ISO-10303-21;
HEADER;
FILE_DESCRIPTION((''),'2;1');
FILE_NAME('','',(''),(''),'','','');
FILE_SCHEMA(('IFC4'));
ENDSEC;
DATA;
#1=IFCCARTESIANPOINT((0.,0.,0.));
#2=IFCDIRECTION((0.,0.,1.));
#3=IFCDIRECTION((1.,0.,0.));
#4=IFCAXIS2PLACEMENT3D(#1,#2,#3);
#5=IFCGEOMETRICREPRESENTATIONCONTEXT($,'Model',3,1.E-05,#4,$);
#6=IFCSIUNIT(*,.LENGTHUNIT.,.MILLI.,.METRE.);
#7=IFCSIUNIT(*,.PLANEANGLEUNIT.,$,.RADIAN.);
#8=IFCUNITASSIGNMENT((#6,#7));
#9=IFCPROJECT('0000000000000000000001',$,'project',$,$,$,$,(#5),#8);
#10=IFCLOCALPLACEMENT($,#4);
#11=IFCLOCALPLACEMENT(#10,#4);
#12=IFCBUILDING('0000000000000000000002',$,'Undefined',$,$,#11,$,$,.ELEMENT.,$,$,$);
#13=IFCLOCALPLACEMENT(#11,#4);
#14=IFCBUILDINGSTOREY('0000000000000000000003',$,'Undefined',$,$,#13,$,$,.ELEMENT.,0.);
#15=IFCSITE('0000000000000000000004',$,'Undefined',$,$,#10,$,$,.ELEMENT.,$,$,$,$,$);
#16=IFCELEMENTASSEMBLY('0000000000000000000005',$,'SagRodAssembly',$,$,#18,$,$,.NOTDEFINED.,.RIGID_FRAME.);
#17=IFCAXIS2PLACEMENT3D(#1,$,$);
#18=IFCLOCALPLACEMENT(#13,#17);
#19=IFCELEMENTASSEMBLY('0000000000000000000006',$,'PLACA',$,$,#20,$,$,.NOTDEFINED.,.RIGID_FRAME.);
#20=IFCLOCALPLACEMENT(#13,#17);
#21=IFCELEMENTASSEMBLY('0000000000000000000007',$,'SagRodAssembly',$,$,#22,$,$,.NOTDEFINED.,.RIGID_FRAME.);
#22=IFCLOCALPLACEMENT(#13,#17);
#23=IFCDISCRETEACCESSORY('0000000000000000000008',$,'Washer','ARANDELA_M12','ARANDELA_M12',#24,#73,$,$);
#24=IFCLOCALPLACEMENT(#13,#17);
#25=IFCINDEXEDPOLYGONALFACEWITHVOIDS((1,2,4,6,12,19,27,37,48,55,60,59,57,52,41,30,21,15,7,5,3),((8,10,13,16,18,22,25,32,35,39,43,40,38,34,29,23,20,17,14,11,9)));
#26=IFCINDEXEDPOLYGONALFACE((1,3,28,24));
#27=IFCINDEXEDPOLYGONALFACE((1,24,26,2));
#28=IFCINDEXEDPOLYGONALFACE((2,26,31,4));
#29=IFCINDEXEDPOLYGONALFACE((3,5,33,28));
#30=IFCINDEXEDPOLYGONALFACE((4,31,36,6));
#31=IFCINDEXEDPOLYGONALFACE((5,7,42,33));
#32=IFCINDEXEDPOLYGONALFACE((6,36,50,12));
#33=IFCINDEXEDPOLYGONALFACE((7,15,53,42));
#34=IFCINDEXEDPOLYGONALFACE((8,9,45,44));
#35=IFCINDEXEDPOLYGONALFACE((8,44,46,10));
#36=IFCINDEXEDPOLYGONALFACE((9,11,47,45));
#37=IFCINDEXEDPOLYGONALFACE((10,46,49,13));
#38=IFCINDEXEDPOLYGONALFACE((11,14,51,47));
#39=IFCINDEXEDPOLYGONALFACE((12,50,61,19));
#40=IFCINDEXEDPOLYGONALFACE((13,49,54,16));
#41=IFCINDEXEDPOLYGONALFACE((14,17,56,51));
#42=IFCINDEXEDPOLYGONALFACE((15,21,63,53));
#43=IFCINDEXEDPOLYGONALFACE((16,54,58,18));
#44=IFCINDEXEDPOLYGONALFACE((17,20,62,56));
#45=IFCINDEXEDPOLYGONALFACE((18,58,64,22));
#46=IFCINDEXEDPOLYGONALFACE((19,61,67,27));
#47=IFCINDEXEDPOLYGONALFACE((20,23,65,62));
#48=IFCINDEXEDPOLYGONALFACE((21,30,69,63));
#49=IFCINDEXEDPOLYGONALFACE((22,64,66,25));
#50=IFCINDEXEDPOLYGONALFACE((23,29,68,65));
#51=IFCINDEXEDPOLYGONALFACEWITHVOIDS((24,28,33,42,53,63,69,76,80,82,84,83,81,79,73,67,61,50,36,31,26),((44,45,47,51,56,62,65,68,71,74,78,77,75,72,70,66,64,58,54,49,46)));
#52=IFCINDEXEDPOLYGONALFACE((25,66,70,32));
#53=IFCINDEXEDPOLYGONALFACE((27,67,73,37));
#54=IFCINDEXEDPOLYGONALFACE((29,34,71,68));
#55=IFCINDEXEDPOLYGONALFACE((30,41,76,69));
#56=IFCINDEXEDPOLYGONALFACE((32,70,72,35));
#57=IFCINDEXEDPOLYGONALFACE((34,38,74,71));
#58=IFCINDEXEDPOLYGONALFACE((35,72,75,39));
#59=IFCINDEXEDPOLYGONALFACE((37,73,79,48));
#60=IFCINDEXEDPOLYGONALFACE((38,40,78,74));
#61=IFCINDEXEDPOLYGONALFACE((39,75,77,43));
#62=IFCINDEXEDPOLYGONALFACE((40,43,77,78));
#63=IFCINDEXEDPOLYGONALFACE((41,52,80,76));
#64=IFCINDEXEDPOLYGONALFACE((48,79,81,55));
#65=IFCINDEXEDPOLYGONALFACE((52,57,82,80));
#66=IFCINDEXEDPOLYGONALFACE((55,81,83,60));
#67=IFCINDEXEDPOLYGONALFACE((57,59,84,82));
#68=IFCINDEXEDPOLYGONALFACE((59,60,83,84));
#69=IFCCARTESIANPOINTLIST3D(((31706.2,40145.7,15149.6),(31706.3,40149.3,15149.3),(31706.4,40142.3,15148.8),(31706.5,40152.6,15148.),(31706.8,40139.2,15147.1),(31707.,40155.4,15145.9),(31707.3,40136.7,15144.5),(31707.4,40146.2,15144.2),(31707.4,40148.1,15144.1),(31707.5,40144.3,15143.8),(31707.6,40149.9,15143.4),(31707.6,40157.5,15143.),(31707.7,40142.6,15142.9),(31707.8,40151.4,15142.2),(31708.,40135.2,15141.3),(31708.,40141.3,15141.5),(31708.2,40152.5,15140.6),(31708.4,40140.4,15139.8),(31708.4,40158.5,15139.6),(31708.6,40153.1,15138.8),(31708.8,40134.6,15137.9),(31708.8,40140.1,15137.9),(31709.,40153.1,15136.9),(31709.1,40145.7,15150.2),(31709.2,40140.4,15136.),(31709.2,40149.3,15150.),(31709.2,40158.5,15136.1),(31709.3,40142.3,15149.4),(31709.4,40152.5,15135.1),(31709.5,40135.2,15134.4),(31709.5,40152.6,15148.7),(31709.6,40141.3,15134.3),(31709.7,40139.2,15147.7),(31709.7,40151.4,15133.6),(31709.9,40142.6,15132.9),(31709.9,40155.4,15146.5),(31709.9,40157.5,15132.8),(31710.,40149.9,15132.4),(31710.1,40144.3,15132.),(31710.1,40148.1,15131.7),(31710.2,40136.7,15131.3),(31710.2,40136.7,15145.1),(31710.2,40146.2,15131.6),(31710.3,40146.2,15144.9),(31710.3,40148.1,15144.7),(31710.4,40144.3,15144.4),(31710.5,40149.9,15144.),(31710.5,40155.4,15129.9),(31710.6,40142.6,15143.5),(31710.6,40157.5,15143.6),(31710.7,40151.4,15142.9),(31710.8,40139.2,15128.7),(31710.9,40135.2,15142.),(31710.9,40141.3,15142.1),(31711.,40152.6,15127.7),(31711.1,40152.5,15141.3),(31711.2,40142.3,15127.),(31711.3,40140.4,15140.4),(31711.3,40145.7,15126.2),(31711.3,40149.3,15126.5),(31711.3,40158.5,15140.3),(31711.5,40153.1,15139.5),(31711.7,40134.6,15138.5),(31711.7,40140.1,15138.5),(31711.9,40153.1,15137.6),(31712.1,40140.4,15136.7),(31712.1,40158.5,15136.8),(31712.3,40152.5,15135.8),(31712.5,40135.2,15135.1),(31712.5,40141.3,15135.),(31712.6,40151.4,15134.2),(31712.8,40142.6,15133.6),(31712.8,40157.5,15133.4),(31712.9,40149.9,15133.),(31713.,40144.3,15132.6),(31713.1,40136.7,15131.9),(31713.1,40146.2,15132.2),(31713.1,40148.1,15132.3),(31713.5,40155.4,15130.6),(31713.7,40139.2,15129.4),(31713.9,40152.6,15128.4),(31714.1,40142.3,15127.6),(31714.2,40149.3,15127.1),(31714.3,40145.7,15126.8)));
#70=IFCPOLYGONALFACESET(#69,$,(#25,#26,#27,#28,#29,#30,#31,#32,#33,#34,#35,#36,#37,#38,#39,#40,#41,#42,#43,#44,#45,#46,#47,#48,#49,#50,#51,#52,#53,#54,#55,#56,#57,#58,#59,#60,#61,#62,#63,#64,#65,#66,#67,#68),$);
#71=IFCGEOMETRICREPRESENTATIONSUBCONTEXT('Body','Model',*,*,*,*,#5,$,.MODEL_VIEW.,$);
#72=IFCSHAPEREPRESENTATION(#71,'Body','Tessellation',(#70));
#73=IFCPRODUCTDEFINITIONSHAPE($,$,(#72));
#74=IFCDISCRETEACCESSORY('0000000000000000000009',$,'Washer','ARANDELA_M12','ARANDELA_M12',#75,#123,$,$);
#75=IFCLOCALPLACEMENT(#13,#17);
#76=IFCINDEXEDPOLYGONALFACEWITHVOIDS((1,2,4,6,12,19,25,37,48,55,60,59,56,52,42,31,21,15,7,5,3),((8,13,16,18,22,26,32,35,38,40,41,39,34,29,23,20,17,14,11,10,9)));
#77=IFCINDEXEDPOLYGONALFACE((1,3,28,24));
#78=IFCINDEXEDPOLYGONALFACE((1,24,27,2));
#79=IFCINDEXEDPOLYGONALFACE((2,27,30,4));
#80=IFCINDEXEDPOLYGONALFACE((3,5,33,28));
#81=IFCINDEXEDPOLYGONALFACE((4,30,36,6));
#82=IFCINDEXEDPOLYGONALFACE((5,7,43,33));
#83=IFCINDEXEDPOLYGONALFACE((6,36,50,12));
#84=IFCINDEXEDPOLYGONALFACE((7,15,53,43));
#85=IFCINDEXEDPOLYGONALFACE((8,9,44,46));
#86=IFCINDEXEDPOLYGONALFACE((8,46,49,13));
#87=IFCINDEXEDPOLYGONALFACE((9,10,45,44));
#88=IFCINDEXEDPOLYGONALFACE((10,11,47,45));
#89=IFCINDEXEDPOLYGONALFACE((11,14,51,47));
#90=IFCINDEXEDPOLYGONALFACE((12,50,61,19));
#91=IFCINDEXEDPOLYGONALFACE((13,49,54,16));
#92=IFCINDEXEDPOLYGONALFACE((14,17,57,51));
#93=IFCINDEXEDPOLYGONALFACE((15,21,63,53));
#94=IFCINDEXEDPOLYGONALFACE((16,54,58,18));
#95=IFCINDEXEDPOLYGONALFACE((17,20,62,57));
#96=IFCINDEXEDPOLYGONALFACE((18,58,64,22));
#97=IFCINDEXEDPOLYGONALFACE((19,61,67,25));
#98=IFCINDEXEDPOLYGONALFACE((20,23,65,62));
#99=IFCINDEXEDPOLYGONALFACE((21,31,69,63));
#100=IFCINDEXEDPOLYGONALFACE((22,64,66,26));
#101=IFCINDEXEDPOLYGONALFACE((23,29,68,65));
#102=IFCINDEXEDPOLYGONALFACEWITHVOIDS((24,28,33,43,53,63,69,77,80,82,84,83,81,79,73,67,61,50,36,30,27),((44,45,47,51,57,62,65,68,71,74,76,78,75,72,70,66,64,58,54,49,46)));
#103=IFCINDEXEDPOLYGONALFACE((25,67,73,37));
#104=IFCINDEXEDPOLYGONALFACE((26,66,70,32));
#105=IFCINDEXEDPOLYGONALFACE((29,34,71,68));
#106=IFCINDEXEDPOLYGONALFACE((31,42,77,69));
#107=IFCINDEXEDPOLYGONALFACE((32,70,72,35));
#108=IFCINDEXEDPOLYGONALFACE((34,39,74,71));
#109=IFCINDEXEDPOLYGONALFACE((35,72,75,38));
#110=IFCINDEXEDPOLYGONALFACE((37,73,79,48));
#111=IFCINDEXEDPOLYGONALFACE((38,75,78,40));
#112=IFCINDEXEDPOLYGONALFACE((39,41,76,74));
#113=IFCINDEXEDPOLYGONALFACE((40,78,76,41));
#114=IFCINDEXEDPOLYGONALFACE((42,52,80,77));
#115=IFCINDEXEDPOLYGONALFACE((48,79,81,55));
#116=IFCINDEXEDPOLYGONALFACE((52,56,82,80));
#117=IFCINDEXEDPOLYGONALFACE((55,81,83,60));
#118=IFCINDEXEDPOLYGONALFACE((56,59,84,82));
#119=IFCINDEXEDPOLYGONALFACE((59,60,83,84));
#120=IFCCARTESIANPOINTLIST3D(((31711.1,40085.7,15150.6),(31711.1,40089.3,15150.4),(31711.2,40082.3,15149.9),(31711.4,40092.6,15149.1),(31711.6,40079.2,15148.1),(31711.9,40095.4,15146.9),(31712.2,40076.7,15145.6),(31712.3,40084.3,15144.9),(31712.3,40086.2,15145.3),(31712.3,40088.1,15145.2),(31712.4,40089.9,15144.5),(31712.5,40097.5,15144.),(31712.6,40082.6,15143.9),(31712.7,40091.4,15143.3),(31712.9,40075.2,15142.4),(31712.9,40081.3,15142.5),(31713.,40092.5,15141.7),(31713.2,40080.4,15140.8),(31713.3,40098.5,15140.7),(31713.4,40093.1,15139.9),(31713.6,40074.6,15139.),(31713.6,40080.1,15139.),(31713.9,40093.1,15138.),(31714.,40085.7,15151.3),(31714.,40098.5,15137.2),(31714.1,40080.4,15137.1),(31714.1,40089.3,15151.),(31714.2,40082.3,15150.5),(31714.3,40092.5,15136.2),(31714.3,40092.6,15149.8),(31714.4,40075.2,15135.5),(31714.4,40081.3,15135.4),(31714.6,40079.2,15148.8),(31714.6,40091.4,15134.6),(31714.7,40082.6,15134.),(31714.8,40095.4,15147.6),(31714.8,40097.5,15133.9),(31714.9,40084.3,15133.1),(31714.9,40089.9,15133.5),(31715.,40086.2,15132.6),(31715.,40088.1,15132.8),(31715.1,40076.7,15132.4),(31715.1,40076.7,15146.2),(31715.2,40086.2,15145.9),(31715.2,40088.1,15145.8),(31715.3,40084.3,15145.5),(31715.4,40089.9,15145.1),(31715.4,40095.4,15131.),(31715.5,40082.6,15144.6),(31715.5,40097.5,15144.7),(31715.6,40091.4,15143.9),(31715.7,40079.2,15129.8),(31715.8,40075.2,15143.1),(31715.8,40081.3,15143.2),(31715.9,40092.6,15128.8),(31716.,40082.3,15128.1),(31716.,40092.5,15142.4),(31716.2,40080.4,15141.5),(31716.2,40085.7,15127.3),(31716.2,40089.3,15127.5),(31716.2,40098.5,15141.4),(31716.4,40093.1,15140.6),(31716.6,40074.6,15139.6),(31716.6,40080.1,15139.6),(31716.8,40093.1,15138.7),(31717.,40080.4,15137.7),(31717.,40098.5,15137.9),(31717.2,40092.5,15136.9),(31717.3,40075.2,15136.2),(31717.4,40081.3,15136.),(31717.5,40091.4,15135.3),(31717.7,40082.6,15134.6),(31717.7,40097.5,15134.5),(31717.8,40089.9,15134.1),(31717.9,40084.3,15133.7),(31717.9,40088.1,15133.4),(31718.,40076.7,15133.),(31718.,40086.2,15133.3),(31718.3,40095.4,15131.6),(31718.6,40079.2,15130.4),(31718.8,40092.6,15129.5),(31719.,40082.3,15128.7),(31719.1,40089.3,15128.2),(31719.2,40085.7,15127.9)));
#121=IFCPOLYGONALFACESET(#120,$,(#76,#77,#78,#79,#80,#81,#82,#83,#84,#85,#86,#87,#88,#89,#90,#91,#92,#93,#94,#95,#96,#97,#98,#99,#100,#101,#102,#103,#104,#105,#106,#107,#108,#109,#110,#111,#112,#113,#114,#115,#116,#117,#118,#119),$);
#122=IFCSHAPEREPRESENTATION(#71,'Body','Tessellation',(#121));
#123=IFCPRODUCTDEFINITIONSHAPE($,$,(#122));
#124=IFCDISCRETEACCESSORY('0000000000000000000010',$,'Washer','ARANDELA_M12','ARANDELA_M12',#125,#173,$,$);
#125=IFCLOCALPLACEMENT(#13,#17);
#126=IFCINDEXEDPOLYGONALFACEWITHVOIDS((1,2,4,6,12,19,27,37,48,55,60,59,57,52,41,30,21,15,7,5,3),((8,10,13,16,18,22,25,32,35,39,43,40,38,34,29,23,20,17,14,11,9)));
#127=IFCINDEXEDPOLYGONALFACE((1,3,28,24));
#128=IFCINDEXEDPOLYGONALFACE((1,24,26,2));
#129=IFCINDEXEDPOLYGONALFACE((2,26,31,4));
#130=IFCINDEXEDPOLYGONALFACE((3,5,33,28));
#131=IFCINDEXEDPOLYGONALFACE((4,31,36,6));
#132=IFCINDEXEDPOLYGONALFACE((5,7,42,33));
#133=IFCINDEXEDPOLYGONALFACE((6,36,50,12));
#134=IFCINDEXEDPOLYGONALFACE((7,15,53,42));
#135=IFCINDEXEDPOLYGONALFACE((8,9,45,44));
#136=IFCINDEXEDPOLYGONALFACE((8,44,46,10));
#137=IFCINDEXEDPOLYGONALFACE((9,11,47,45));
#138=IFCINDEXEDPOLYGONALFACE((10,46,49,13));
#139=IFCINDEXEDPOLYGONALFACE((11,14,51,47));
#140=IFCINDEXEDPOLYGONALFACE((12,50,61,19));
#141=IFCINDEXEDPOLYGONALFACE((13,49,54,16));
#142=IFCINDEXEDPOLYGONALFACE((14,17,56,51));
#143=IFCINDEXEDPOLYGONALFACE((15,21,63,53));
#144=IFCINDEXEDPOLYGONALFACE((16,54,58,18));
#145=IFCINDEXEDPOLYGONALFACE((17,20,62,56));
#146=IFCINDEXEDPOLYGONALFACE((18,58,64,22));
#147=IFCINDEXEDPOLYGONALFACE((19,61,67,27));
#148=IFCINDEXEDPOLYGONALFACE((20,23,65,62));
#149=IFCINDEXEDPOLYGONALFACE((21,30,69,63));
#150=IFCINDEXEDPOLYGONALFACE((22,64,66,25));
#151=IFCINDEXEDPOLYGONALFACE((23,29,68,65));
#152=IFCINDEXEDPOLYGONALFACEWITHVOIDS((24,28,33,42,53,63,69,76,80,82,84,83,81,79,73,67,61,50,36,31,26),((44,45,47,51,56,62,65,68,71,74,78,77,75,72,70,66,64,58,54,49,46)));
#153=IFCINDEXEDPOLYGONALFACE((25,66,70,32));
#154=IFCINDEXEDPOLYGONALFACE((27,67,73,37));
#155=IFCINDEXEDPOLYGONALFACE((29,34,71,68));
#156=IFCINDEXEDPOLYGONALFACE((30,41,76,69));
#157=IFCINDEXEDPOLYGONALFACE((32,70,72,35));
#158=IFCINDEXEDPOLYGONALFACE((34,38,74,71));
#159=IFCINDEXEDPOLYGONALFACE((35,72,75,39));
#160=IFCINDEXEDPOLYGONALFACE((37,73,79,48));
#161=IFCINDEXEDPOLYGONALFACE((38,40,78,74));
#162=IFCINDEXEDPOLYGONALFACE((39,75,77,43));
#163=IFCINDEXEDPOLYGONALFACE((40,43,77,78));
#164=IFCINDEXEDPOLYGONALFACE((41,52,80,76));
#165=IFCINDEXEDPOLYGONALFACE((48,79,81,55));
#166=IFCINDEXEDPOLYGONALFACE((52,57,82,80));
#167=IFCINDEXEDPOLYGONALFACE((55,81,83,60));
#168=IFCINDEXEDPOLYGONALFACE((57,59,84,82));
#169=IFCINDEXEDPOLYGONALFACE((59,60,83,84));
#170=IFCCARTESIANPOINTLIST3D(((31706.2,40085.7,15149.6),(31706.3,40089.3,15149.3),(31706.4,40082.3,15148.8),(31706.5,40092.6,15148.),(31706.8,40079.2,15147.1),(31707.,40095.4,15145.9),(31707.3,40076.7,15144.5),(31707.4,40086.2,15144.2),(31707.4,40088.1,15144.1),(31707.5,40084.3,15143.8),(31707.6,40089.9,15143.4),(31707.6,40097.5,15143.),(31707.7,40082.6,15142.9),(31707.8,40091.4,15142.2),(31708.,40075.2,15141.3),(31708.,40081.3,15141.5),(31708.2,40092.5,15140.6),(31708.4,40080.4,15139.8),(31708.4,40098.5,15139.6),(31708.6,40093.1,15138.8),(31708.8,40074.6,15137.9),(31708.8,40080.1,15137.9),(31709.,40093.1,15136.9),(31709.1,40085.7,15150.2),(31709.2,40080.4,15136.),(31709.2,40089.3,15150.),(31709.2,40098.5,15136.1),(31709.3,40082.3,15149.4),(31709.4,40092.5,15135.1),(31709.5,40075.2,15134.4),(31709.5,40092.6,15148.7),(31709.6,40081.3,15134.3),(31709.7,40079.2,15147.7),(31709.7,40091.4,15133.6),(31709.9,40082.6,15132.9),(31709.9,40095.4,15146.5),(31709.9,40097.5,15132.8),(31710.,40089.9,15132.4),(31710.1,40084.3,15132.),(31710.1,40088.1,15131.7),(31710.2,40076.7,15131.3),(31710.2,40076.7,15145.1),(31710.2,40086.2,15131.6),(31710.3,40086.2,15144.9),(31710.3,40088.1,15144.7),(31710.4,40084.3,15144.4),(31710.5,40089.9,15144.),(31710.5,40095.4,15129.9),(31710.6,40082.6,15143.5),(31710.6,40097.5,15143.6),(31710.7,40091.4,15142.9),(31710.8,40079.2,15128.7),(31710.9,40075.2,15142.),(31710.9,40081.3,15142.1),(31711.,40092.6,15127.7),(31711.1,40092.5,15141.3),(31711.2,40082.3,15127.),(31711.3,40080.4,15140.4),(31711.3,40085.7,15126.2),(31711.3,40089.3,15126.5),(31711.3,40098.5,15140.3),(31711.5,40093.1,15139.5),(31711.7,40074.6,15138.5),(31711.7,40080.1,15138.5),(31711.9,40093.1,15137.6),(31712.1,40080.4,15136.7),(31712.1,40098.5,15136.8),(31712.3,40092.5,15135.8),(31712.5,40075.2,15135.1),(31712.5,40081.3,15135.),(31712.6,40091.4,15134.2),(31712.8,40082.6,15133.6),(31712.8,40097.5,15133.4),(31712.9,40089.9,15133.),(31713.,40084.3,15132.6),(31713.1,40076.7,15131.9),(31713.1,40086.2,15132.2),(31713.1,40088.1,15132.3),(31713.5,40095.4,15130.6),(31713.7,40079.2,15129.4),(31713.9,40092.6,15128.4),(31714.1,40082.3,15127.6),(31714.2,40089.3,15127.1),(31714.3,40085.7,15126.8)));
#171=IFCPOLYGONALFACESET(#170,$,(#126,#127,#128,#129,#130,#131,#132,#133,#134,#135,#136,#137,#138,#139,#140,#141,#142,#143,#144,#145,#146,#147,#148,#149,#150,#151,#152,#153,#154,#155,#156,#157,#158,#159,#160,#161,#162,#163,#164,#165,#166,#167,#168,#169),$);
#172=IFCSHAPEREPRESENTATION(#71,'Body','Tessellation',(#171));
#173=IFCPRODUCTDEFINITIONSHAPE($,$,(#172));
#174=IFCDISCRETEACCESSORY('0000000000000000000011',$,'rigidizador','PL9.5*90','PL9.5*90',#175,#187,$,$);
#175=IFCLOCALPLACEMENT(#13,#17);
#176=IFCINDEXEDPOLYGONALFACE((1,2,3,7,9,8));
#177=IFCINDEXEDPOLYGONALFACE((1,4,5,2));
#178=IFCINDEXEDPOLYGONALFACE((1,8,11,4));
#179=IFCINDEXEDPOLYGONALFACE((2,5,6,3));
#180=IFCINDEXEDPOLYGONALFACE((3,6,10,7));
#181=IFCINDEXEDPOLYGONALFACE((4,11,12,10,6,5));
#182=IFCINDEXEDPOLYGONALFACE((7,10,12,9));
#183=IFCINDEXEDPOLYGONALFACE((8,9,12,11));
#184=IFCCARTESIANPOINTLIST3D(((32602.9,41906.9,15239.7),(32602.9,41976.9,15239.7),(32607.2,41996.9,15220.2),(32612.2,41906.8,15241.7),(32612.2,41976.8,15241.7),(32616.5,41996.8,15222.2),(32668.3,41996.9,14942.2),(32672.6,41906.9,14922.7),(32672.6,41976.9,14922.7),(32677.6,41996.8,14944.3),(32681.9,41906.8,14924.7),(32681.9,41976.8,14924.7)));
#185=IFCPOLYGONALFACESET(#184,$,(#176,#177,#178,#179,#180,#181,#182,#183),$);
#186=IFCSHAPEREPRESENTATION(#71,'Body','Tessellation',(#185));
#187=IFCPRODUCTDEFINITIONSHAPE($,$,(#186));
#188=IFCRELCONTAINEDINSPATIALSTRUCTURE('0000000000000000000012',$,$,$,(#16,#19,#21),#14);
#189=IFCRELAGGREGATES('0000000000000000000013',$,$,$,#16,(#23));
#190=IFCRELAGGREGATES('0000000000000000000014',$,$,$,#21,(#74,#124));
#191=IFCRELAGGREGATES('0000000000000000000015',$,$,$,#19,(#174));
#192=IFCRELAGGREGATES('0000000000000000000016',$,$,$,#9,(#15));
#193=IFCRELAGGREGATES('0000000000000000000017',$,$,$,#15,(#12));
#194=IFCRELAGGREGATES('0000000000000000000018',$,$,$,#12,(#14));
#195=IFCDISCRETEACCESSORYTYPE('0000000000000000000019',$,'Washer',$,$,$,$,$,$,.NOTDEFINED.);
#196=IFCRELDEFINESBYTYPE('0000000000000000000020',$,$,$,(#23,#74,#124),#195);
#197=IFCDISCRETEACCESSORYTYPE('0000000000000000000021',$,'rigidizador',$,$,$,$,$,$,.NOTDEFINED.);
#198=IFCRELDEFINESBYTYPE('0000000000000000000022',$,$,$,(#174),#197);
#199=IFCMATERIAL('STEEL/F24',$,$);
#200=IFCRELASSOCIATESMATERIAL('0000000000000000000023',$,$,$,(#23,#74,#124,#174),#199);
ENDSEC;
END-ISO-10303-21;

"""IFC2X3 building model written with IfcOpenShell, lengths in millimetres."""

from ifc_helpers import new_model, si_unit, frame, origin_with_axes, origin_2d_with_axis, place, context, subcontext, project, spatial, polyline, hollow_circle, outline, extrude, material, type_object, element, aggregate, save


model = new_model("IFC2X3")

# Units and contexts
model_context = context("Model", 3, precision=1e-05, world=origin_with_axes())
body_context = subcontext(model_context, "Body", "Model", "MODEL_VIEW")
ifc_project = project(units=[si_unit("LENGTHUNIT", "METRE", prefix="MILLI"), si_unit("PLANEANGLEUNIT", "RADIAN")], contexts=[model_context])

# Site, building, storey
site_placement = place(None, origin_with_axes())
site = spatial("IfcSite", under=ifc_project, at=site_placement, Name="Undefined", CompositionType="ELEMENT")
building_placement = place(site_placement, origin_with_axes())
building = spatial("IfcBuilding", under=site, at=building_placement, Name="Undefined", CompositionType="ELEMENT")
storey_placement = place(building_placement, origin_with_axes())
storey = spatial("IfcBuildingStorey", under=building, at=storey_placement, Name="Undefined", CompositionType="ELEMENT", Elevation=0.0)

# Element assembly
assembly_1_placement = place(storey_placement, origin_with_axes())
assembly_1 = element("IfcElementAssembly", 1, at=assembly_1_placement, inside=storey, Name="SagRodAssembly", AssemblyPlace="NOTDEFINED", PredefinedType="RIGID_FRAME")
ifc_material_1 = material(Name="STEEL/F24")

# Element assembly
assembly_2_placement = place(storey_placement, origin_with_axes())
assembly_2 = element("IfcElementAssembly", 2, at=assembly_2_placement, inside=storey, Name="PLACA", AssemblyPlace="NOTDEFINED", PredefinedType="RIGID_FRAME")

# Element assembly
assembly_3_placement = place(storey_placement, origin_with_axes())
assembly_3 = element("IfcElementAssembly", 3, at=assembly_3_placement, inside=storey, Name="SagRodAssembly", AssemblyPlace="NOTDEFINED", PredefinedType="RIGID_FRAME")

# Discrete accessories
discrete_accessory_type_1 = type_object("IfcDiscreteAccessoryType", Name="Washer")
discrete_accessory_1_placement = place(assembly_1_placement, frame((31708.8, 40146.6, 15137.9), z_axis=(-0.214887, 0.0, 0.976639), x_axis=(0.976639, 0.0, 0.214887)))
discrete_accessory_1 = element("IfcDiscreteAccessory", 4, at=discrete_accessory_1_placement, type_object=discrete_accessory_type_1, material=ifc_material_1, Name="Washer", Description="ARANDELA_M12", ObjectType="ARANDELA_M12", context=body_context, shape_type="SweptSolid", body=[
    extrude(hollow_circle(Radius=12.0, WallThickness=5.5, at=origin_2d_with_axis()), frame((3.0, 0.0, 0.0), z_axis=(-1.0, 0.0, 0.0), x_axis=(0.0, -1.0, 0.0)), (0.0, 0.0, 1.0), 3.0),
])
aggregate(assembly_1, [discrete_accessory_1])
discrete_accessory_2_placement = place(assembly_3_placement, frame((31713.6, 40086.6, 15139.0), z_axis=(-0.214887, 0.0, 0.976639), x_axis=(0.976639, 0.0, 0.214887)))
discrete_accessory_2 = element("IfcDiscreteAccessory", 5, at=discrete_accessory_2_placement, type_object=discrete_accessory_type_1, material=ifc_material_1, Name="Washer", Description="ARANDELA_M12", ObjectType="ARANDELA_M12", context=body_context, shape_type="SweptSolid", body=[
    extrude(hollow_circle(Radius=12.0, WallThickness=5.5, at=origin_2d_with_axis()), frame((3.0, 0.0, 0.0), z_axis=(-1.0, 0.0, 0.0), x_axis=(0.0, -1.0, 0.0)), (0.0, 0.0, 1.0), 3.0),
])
discrete_accessory_3_placement = place(assembly_3_placement, frame((31708.8, 40086.6, 15137.9), z_axis=(-0.214887, 0.0, 0.976639), x_axis=(0.976639, 0.0, 0.214887)))
discrete_accessory_3 = element("IfcDiscreteAccessory", 6, at=discrete_accessory_3_placement, type_object=discrete_accessory_type_1, material=ifc_material_1, Name="Washer", Description="ARANDELA_M12", ObjectType="ARANDELA_M12", context=body_context, shape_type="SweptSolid", body=[
    extrude(hollow_circle(Radius=12.0, WallThickness=5.5, at=origin_2d_with_axis()), frame((3.0, 0.0, 0.0), z_axis=(-1.0, 0.0, 0.0), x_axis=(0.0, -1.0, 0.0)), (0.0, 0.0, 1.0), 3.0),
])
aggregate(assembly_3, [discrete_accessory_2, discrete_accessory_3])

# Discrete accessory
discrete_accessory_type_2 = type_object("IfcDiscreteAccessoryType", Name="rigidizador")
discrete_accessory_4_placement = place(assembly_2_placement, frame((32677.3, 41906.8, 14923.7), z_axis=(0.976639, 0.0, 0.214887), x_axis=(0.0, 1.0, 0.0)))
discrete_accessory_4 = element("IfcDiscreteAccessory", 7, at=discrete_accessory_4_placement, type_object=discrete_accessory_type_2, material=ifc_material_1, Name="rigidizador", Description="PL9.5*90", ObjectType="PL9.5*90", context=body_context, shape_type="SweptSolid", body=[
    extrude(outline(polyline([(0.0, 0.0), (70.0, 0.0), (90.0, 20.0), (90.0, 304.6), (70.0, 324.6), (0.0, 324.6), (0.0, 0.0)])), frame((0.0, 0.0, -4.8), z_axis=(0.0, 0.0, 1.0), x_axis=(1.0, 0.0, 0.0)), (0.0, 0.0, 1.0), 9.5),
])

aggregate(assembly_2, [discrete_accessory_4])

save(model, "model.ifc")
